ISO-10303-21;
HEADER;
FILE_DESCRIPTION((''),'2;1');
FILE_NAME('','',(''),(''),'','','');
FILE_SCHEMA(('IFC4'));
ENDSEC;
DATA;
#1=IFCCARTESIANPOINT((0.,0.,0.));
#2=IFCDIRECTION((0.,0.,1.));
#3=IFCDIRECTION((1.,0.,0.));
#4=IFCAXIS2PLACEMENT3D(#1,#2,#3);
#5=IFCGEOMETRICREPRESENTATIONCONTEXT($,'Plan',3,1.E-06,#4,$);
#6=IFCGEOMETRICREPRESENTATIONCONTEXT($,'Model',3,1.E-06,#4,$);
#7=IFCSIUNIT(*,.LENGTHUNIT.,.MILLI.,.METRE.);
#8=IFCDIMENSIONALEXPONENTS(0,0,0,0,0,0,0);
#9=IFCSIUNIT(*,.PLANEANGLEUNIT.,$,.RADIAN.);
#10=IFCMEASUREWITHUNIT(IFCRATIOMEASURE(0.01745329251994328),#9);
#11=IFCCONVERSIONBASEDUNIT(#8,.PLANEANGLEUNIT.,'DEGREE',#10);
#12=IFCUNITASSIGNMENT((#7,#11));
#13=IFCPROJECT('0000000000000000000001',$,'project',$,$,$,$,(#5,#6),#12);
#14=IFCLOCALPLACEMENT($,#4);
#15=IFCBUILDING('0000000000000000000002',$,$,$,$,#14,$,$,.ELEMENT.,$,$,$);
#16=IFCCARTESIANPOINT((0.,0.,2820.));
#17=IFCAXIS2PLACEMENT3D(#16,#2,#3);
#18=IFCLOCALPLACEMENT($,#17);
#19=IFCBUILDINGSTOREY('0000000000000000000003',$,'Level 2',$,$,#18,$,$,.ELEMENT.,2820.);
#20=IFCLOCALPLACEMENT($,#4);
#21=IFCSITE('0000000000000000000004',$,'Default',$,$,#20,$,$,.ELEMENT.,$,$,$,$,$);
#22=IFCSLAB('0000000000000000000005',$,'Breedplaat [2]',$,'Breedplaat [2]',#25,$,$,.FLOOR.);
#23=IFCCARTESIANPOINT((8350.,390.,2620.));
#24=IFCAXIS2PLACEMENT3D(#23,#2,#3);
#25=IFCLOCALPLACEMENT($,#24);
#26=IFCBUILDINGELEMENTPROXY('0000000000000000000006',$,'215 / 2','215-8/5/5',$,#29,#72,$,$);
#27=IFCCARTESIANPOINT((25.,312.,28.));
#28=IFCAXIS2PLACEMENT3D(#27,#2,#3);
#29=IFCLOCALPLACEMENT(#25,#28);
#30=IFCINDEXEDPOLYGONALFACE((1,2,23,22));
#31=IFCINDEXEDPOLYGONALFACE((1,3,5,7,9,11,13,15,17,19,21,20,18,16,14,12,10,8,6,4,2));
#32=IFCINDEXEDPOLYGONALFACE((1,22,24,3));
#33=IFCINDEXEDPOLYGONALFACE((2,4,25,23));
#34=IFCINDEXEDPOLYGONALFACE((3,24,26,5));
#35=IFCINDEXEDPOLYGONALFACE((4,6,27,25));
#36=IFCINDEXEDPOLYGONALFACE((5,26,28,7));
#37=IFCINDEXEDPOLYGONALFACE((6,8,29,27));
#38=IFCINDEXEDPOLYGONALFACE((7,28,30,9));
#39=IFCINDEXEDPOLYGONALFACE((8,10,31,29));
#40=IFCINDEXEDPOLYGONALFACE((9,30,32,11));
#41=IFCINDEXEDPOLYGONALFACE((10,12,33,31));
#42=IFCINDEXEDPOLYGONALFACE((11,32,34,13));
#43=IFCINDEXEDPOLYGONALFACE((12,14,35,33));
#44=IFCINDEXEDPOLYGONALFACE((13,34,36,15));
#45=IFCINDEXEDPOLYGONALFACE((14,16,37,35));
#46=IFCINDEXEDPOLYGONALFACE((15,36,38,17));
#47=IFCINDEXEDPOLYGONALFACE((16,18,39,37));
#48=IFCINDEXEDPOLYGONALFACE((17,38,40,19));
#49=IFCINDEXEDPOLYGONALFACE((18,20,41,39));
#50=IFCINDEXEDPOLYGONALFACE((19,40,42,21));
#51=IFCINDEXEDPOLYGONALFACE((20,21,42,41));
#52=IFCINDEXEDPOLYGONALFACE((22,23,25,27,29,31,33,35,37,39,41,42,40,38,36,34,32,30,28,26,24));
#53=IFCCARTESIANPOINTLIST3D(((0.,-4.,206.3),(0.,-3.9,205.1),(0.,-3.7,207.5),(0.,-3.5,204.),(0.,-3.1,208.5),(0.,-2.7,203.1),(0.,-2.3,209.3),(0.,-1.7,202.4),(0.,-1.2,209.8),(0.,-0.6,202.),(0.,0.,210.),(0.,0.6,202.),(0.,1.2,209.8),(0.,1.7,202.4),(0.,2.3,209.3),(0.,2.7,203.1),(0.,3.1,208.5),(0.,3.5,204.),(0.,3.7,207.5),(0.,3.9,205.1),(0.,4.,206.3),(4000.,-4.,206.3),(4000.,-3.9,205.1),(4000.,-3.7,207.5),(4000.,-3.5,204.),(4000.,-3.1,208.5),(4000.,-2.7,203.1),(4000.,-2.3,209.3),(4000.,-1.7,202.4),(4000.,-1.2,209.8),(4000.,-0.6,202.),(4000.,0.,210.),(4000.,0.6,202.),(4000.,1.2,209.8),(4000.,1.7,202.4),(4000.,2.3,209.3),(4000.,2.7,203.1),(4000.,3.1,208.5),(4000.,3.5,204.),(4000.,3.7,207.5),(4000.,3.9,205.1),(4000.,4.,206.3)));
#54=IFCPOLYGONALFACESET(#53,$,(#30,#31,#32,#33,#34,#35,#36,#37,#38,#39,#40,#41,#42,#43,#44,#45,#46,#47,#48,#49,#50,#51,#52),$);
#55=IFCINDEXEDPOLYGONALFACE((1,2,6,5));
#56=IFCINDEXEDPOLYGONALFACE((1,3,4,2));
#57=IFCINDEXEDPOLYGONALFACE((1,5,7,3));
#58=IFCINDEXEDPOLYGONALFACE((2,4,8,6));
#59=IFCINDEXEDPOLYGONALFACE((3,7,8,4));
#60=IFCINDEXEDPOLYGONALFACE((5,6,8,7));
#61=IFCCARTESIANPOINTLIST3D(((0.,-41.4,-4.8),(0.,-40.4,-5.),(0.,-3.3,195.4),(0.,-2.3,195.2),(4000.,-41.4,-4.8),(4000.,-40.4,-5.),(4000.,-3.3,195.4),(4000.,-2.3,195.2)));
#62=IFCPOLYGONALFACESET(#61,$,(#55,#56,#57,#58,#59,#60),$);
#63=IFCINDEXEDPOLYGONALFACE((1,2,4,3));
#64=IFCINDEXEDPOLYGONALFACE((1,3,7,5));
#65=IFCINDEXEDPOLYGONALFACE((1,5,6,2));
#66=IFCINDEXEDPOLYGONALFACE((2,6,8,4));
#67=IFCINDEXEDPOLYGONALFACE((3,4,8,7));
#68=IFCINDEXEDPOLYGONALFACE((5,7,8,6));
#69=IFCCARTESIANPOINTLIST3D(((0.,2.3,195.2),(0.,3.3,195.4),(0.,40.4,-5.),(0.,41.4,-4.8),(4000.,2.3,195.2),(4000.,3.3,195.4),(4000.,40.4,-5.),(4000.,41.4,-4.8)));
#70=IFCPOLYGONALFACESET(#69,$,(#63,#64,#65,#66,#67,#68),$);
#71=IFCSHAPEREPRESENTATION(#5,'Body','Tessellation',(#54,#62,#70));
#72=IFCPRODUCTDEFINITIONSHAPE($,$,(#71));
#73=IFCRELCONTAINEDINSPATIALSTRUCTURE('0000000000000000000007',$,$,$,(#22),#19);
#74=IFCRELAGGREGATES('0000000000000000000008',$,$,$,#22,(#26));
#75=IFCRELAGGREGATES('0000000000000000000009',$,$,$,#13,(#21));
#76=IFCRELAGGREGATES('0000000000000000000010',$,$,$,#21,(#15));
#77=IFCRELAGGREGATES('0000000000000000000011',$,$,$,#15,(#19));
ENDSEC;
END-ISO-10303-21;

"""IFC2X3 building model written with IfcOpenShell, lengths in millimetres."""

from ifc_helpers import new_model, entity, si_unit, converted_unit, frame, origin_with_axes, origin_2d_with_axis, place, context, project, spatial, rectangle, circle, extrude, element, aggregate, save


model = new_model("IFC2X3")

# Units and contexts
plan_context = context("Plan", 3, precision=1e-06, world=origin_with_axes())
model_context = context("Model", 3, precision=1e-06, world=origin_with_axes())
ifc_project = project(units=[si_unit("LENGTHUNIT", "METRE", prefix="MILLI"), converted_unit("PLANEANGLEUNIT", "DEGREE", entity("IfcRatioMeasure", 0.01745329251994328), si_unit("PLANEANGLEUNIT", "RADIAN"), dimensions=[0, 0, 0, 0, 0, 0, 0])], contexts=[plan_context, model_context])

# Site, building, storey
site_placement = place(None, origin_with_axes())
site = spatial("IfcSite", under=ifc_project, at=site_placement, Name="Default", CompositionType="ELEMENT")
building_placement = place(None, origin_with_axes())
building = spatial("IfcBuilding", under=site, at=building_placement, CompositionType="ELEMENT")
storey_placement = place(None, frame((0.0, 0.0, 2820.0), z_axis=(0.0, 0.0, 1.0), x_axis=(1.0, 0.0, 0.0)))
storey = spatial("IfcBuildingStorey", under=building, at=storey_placement, Name="Level 2", CompositionType="ELEMENT", Elevation=2820.0)

# Slab, building element proxy
slab_1_placement = place(None, frame((8350.0, 390.0, 2620.0), z_axis=(0.0, 0.0, 1.0), x_axis=(1.0, 0.0, 0.0)))
slab_1 = element("IfcSlab", 1, at=slab_1_placement, inside=storey, Name="Breedplaat [2]", ObjectType="Breedplaat [2]", PredefinedType="FLOOR")
proxy_1_placement = place(slab_1_placement, frame((25.0, 312.0, 28.0), z_axis=(0.0, 0.0, 1.0), x_axis=(1.0, 0.0, 0.0)))
proxy_1 = element("IfcBuildingElementProxy", 2, at=proxy_1_placement, Name="215 / 2", Description="215-8/5/5", context=plan_context, shape_type="SweptSolid", body=[
    extrude(circle(Radius=4.0, at=origin_2d_with_axis()), frame((0.0, 0.0, 206.0), z_axis=(1.0, 0.0, 0.0), x_axis=(0.0, 0.0, 1.0)), (0.0, 0.0, 1.0), 4000.0),
    extrude(rectangle(XDim=203.8, YDim=1.0, at=origin_2d_with_axis()), frame((0.0, -21.9, 95.2), z_axis=(1.0, 0.0, 0.0), x_axis=(0.0, 0.187112, 0.982339)), (0.0, 0.0, 1.0), 4000.0),
    extrude(rectangle(XDim=203.8, YDim=1.0, at=origin_2d_with_axis()), frame((0.0, 21.9, 95.2), z_axis=(1.0, 0.0, 0.0), x_axis=(0.0, -0.187112, 0.982339)), (0.0, 0.0, 1.0), 4000.0),
])
aggregate(slab_1, [proxy_1])

save(model, "model.ifc")
